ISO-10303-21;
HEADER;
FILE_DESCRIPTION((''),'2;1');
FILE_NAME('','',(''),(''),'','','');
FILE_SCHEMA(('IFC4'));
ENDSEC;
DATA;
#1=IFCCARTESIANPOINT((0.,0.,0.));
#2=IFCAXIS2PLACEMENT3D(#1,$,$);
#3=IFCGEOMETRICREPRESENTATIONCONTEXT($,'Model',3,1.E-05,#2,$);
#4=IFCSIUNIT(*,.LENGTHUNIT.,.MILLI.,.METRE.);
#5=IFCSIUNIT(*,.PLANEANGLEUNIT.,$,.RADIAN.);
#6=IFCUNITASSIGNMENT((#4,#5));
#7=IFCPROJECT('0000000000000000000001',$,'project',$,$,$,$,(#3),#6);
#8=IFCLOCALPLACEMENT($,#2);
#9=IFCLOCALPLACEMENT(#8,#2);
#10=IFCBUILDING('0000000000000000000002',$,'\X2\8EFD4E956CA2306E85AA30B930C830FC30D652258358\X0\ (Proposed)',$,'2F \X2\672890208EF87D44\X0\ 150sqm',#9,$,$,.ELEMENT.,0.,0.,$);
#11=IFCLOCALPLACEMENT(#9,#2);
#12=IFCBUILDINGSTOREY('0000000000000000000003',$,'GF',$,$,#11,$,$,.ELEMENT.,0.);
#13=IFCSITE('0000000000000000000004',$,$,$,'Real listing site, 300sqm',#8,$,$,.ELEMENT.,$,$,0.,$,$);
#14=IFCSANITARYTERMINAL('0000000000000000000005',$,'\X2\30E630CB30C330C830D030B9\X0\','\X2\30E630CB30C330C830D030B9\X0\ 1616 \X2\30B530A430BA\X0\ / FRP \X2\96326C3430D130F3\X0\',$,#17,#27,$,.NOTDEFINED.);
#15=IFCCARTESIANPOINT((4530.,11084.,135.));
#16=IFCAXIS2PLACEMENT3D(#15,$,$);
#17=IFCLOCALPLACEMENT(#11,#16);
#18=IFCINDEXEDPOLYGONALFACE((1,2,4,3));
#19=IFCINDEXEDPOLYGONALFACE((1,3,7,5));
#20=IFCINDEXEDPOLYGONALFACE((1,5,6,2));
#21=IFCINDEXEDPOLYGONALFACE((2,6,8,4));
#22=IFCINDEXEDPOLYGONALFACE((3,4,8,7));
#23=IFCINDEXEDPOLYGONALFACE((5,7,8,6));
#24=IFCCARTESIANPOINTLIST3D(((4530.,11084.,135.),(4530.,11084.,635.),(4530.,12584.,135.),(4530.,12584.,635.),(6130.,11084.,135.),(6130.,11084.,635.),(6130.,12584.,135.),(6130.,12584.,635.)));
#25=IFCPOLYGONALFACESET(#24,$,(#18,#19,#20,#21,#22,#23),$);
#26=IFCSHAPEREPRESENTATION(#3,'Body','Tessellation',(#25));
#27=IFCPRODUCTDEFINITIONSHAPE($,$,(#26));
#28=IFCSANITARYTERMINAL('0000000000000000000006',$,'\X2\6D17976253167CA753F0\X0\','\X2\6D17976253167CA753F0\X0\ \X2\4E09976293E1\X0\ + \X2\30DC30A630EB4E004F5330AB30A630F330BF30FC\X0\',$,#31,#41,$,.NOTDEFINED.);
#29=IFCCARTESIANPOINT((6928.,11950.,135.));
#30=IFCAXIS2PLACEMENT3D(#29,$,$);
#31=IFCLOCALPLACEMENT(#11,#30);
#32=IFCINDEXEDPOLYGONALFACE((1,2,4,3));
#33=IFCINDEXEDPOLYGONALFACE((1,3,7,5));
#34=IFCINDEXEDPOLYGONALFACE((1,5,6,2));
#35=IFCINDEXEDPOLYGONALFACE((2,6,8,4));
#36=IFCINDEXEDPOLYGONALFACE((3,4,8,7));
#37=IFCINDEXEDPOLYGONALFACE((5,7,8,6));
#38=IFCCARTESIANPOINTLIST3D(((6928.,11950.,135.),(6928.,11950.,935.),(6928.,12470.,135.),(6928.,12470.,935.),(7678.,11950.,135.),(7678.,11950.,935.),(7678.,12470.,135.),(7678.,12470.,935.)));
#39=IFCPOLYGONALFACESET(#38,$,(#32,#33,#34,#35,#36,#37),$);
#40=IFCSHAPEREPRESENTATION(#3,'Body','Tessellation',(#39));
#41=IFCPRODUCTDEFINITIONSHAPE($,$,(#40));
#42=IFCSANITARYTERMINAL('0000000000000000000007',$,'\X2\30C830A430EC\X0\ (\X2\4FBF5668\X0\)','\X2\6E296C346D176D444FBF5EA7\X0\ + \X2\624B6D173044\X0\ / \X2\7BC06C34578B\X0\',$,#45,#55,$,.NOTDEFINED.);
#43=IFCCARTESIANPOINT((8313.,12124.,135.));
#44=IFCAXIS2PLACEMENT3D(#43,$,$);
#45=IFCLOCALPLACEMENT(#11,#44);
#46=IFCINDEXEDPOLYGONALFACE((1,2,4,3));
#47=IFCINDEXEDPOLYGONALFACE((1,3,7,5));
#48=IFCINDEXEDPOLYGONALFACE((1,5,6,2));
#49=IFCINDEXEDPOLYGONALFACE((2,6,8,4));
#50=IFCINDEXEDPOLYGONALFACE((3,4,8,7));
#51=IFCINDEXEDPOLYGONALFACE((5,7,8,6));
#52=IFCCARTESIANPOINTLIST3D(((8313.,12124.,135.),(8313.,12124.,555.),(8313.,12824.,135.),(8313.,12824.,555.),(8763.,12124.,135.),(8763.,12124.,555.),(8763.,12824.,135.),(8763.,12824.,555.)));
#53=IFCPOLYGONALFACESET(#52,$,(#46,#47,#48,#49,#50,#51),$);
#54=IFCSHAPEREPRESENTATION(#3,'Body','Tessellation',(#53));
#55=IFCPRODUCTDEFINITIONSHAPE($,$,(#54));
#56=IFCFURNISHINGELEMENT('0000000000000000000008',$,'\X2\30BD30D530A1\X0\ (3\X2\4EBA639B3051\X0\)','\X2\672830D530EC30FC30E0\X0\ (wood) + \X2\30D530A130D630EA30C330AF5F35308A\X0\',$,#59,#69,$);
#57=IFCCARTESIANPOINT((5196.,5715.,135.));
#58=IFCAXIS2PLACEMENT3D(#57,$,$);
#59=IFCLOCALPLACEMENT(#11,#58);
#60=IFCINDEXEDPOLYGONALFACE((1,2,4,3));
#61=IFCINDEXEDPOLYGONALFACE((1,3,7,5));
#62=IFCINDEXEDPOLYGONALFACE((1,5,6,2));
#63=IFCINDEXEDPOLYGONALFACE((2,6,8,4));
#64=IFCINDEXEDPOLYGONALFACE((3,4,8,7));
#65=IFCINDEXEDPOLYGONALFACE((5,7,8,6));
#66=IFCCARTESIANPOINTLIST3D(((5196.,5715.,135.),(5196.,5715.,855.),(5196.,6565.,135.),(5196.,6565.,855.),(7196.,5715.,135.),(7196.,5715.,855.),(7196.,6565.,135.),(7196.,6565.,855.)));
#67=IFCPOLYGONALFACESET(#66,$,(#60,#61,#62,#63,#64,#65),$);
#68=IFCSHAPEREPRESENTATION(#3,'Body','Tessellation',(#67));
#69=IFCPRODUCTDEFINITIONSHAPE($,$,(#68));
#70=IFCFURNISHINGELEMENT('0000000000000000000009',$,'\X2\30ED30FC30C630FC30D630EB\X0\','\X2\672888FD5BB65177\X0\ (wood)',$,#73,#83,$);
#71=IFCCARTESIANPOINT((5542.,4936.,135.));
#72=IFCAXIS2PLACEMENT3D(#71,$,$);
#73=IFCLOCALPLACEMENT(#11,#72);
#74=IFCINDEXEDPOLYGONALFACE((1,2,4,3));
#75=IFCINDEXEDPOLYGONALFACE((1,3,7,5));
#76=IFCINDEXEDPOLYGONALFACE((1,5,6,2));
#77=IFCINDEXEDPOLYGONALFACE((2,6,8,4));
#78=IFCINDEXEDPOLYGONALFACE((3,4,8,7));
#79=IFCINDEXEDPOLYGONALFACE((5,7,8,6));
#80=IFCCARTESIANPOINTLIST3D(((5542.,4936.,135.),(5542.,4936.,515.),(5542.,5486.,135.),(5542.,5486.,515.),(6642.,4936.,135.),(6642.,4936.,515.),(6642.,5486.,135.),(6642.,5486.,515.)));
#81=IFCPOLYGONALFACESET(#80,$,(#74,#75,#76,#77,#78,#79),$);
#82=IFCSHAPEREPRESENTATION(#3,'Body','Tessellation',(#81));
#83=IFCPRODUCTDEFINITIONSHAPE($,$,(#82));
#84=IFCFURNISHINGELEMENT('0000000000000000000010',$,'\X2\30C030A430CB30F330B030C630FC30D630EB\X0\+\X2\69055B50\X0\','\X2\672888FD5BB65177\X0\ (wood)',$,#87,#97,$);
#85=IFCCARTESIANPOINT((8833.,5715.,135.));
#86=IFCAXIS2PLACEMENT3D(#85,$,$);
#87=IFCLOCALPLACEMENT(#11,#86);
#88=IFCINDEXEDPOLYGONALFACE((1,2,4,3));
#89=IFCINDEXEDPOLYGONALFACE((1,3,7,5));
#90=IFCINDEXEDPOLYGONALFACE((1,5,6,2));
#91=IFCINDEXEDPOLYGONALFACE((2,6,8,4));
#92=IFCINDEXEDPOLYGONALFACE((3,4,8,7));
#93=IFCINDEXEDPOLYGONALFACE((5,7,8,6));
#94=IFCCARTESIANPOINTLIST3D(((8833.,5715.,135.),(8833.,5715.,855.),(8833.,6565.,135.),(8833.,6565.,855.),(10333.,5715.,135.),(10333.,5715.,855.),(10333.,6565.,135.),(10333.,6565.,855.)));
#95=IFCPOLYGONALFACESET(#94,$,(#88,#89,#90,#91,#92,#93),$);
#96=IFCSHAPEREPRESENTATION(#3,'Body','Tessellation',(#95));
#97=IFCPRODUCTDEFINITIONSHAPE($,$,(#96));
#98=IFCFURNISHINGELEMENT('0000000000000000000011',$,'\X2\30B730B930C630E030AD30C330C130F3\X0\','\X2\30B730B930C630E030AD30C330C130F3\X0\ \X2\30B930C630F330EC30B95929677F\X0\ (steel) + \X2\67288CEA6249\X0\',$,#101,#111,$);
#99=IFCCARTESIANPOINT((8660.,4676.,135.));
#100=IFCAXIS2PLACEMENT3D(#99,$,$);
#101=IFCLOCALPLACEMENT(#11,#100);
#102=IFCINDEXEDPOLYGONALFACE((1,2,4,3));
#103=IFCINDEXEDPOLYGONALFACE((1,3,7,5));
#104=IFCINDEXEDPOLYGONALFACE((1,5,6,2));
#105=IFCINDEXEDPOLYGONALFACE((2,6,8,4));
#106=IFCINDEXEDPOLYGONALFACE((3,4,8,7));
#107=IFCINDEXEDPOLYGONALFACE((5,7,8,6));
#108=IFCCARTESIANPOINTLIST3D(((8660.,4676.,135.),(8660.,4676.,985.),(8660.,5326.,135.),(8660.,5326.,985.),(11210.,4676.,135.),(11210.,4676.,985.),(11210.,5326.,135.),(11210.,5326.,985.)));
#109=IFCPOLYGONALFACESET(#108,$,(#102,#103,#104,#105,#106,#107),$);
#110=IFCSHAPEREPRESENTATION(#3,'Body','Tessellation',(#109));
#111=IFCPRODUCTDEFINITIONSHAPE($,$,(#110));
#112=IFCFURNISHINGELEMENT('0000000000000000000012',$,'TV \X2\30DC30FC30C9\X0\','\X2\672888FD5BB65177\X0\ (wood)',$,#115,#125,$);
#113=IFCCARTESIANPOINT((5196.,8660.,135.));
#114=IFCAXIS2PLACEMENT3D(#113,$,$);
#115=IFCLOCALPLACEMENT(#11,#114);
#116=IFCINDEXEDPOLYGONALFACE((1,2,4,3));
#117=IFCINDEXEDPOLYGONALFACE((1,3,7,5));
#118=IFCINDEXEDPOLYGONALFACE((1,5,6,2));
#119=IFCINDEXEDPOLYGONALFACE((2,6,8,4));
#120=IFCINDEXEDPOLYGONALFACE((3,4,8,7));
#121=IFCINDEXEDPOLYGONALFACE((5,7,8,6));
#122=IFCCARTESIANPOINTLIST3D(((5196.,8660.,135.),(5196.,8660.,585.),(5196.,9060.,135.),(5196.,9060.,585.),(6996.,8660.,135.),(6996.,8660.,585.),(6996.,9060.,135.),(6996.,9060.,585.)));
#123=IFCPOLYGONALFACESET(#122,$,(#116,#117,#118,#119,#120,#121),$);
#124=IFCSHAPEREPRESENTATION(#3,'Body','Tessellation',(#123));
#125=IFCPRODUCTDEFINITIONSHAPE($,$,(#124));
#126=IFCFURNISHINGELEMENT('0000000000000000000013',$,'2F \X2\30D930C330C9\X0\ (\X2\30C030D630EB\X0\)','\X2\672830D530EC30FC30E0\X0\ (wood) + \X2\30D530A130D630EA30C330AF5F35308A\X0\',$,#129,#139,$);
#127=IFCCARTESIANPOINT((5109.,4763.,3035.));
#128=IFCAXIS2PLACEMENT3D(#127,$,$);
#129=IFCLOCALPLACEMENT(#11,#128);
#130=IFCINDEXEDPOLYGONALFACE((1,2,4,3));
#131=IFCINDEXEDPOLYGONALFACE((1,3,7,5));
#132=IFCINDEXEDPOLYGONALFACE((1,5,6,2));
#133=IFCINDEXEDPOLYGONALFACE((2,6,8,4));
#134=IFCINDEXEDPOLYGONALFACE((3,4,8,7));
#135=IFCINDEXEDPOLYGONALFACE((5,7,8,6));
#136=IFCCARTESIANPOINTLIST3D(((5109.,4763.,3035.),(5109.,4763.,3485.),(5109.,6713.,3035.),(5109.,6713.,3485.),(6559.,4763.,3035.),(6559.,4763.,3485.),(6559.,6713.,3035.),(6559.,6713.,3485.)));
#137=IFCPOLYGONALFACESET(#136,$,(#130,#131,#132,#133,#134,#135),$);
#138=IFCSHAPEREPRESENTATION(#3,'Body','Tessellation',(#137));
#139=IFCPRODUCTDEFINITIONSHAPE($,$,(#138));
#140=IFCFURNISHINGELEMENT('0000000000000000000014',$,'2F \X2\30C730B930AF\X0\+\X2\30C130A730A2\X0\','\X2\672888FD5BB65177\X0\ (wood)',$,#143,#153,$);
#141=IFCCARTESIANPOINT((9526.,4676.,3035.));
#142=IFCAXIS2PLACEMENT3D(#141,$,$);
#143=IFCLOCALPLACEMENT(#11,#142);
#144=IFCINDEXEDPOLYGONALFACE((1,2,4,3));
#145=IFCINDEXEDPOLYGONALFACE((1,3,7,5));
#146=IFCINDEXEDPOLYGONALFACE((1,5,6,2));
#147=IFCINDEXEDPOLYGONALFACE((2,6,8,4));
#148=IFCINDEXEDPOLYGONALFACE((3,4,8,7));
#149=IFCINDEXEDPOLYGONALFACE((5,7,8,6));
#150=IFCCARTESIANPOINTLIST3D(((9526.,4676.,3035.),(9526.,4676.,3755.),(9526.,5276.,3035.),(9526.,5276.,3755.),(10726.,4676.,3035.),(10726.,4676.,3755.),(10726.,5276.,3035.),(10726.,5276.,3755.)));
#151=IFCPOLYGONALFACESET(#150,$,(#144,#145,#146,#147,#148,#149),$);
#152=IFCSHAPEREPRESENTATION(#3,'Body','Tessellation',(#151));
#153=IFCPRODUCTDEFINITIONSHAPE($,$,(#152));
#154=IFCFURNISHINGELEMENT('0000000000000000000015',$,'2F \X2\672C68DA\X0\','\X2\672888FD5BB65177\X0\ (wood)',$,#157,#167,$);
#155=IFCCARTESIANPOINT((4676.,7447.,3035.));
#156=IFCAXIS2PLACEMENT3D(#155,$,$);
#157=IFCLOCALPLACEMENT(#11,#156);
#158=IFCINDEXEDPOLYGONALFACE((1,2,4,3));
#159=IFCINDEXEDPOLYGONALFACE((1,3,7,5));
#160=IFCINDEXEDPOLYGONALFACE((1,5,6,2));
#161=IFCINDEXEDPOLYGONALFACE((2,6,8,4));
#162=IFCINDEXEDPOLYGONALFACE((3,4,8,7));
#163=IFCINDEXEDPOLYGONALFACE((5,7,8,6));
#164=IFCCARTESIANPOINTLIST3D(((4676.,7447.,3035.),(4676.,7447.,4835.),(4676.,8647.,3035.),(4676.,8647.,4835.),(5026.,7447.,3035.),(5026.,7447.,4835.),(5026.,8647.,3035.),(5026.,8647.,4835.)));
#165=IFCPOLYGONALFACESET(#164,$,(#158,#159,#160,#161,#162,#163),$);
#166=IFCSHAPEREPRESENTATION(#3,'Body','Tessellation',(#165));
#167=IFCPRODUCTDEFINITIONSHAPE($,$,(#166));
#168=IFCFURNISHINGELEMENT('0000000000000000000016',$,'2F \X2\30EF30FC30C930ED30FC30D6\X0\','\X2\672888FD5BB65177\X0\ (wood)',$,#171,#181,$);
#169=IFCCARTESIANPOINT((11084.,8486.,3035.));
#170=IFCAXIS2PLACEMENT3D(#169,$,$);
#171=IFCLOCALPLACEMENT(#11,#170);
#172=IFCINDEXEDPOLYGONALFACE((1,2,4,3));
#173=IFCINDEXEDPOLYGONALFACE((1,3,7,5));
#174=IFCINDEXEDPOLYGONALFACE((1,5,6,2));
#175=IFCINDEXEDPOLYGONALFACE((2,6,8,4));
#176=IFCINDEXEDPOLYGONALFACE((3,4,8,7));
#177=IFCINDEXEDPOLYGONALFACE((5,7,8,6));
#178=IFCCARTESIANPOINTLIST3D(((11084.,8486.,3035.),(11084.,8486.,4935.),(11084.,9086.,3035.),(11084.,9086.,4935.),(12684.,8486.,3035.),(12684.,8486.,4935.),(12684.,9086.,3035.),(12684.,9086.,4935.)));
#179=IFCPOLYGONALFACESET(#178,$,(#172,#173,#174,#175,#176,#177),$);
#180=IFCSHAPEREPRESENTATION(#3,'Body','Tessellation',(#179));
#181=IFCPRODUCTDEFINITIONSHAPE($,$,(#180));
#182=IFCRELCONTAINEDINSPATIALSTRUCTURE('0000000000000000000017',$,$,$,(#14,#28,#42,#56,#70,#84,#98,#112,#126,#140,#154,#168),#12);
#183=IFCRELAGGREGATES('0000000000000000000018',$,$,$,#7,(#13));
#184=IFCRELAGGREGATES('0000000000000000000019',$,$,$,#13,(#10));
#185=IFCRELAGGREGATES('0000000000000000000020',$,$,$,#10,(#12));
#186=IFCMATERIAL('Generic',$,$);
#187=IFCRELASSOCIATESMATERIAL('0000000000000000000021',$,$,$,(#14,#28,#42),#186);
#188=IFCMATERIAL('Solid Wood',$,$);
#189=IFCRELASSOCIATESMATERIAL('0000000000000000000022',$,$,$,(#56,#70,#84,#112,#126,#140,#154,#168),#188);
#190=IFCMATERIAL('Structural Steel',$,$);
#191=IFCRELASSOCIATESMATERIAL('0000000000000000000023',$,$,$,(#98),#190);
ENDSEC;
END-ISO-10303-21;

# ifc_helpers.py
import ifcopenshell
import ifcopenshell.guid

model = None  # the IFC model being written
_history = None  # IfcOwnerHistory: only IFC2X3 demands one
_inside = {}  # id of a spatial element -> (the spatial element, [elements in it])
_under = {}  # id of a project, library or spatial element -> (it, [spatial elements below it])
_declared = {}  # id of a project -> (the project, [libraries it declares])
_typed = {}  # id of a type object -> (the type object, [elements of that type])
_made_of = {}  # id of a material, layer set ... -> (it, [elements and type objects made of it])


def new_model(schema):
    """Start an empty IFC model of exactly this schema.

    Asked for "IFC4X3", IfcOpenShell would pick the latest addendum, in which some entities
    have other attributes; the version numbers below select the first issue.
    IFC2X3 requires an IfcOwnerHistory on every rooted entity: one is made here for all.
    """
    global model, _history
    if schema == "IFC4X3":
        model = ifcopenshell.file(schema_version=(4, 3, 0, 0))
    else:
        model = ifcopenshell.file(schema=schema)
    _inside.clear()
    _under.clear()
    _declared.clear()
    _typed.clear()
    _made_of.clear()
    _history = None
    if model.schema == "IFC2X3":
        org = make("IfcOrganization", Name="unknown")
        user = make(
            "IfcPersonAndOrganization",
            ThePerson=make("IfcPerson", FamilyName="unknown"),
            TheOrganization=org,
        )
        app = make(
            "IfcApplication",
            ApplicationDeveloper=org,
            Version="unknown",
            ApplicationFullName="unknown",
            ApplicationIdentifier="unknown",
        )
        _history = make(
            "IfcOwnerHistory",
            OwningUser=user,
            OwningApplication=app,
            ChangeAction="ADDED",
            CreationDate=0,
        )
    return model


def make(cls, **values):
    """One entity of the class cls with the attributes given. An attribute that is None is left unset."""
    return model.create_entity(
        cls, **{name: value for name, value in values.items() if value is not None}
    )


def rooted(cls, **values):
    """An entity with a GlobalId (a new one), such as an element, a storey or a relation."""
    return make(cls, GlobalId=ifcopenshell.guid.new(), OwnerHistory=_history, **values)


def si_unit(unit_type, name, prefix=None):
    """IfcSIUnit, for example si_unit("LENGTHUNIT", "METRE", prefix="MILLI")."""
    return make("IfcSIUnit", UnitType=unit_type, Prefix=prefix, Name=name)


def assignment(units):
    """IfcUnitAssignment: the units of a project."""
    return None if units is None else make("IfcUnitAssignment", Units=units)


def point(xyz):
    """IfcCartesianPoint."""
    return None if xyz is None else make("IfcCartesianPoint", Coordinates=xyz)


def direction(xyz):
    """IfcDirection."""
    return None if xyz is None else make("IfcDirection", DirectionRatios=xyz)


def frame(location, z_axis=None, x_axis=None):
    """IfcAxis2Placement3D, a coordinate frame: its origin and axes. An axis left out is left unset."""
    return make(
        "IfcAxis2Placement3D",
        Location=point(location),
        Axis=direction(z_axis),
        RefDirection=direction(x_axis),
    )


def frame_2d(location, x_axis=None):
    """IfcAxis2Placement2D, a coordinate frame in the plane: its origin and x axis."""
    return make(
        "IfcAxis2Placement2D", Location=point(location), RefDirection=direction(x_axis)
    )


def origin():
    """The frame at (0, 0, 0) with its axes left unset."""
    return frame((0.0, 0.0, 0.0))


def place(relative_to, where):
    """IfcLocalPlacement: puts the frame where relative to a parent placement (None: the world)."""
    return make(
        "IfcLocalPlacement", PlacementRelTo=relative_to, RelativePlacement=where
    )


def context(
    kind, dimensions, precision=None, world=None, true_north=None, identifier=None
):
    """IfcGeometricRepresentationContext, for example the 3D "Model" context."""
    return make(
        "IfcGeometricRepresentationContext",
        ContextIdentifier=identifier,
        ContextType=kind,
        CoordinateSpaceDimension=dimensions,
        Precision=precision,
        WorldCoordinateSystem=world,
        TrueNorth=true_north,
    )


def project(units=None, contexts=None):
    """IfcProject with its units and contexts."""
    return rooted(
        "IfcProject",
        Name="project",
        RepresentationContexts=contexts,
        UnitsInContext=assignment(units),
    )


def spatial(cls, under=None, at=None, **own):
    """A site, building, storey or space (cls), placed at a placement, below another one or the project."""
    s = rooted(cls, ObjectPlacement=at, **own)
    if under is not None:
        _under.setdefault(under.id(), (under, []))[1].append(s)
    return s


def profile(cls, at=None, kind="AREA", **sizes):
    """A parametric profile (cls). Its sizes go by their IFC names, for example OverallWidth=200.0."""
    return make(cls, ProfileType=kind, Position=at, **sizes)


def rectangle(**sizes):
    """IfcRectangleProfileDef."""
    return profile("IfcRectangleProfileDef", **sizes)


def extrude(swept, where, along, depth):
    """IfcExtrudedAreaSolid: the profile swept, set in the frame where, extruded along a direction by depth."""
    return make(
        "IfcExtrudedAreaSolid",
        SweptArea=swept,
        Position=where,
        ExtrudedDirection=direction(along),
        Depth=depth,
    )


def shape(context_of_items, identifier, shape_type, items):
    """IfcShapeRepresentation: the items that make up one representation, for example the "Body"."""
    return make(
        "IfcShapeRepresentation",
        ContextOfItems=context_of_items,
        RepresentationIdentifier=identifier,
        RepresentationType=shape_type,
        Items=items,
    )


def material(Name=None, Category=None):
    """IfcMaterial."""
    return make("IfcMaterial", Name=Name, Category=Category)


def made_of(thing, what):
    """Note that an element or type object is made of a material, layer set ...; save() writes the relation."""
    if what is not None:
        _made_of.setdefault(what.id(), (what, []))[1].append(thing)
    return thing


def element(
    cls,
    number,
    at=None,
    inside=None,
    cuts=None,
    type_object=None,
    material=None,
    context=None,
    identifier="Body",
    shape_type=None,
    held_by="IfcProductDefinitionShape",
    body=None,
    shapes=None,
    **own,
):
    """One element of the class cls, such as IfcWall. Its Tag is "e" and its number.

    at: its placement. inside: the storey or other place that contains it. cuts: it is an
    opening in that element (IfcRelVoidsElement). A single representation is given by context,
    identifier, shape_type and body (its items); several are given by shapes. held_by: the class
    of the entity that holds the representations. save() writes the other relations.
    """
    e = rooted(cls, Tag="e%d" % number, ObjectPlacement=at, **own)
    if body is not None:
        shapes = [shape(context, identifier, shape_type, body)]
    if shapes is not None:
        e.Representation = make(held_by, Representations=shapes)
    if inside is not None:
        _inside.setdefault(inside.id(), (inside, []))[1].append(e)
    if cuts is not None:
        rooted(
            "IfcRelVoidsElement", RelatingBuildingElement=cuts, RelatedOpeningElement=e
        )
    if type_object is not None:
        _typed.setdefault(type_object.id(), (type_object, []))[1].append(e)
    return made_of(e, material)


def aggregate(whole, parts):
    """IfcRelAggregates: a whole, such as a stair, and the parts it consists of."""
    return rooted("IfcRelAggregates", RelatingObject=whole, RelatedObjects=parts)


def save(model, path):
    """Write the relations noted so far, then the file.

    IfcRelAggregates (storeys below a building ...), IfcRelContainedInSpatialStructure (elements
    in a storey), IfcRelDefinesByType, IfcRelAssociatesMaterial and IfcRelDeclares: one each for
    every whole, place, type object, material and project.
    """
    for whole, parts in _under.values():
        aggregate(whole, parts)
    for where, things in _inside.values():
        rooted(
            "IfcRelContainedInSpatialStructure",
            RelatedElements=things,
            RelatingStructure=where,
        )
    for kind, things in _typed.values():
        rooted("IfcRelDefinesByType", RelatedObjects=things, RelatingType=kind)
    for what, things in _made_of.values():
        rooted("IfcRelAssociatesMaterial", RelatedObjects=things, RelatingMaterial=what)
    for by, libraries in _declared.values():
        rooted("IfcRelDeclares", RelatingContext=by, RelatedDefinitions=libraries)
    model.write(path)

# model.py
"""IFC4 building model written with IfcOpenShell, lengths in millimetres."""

from ifc_helpers import new_model, si_unit, frame, frame_2d, origin, place, context, project, spatial, rectangle, extrude, material, element, save


model = new_model("IFC4")

# Units and contexts
model_context = context("Model", 3, precision=1e-05, world=origin())
ifc_project = project(units=[si_unit("LENGTHUNIT", "METRE", prefix="MILLI"), si_unit("PLANEANGLEUNIT", "RADIAN")], contexts=[model_context])

# Site, building, storey
site_placement = place(None, origin())
site = spatial("IfcSite", under=ifc_project, at=site_placement, ObjectType="Real listing site, 300sqm", CompositionType="ELEMENT", RefElevation=0.0)
building_placement = place(site_placement, origin())
building = spatial("IfcBuilding", under=site, at=building_placement, Name="軽井沢の薪ストーブ別荘 (Proposed)", ObjectType="2F 木造軸組 150sqm", CompositionType="ELEMENT", ElevationOfRefHeight=0.0, ElevationOfTerrain=0.0)
storey_placement = place(building_placement, origin())
storey = spatial("IfcBuildingStorey", under=building, at=storey_placement, Name="GF", CompositionType="ELEMENT", Elevation=0.0)

# Shared definitions
ifc_material_1 = material(Name="Solid Wood")

# Sanitary terminals
ifc_material_2 = material(Name="Generic")
sanitary_terminal_1_placement = place(storey_placement, frame((4530.0, 11084.0, 135.0)))
element("IfcSanitaryTerminal", 1, at=sanitary_terminal_1_placement, inside=storey, material=ifc_material_2, Name="ユニットバス", Description="ユニットバス 1616 サイズ / FRP 防水パン", PredefinedType="NOTDEFINED", context=model_context, shape_type="SweptSolid", body=[
    extrude(rectangle(XDim=1600.0, YDim=1500.0, at=frame_2d((800.0, 750.0))), frame((4530.0, 11084.0, 135.0)), (0.0, 0.0, 1.0), 500.0),
])
sanitary_terminal_2_placement = place(storey_placement, frame((6928.0, 11950.0, 135.0)))
element("IfcSanitaryTerminal", 2, at=sanitary_terminal_2_placement, inside=storey, material=ifc_material_2, Name="洗面化粧台", Description="洗面化粧台 三面鏡 + ボウル一体カウンター", PredefinedType="NOTDEFINED", context=model_context, shape_type="SweptSolid", body=[
    extrude(rectangle(XDim=750.0, YDim=520.0, at=frame_2d((375.0, 260.0))), frame((6928.0, 11950.0, 135.0)), (0.0, 0.0, 1.0), 800.0),
])
sanitary_terminal_3_placement = place(storey_placement, frame((8313.0, 12124.0, 135.0)))
element("IfcSanitaryTerminal", 3, at=sanitary_terminal_3_placement, inside=storey, material=ifc_material_2, Name="トイレ (便器)", Description="温水洗浄便座 + 手洗い / 節水型", PredefinedType="NOTDEFINED", context=model_context, shape_type="SweptSolid", body=[
    extrude(rectangle(XDim=450.0, YDim=700.0, at=frame_2d((225.0, 350.0))), frame((8313.0, 12124.0, 135.0)), (0.0, 0.0, 1.0), 420.0),
])

# Furnishing elements
furnishing_1_placement = place(storey_placement, frame((5196.0, 5715.0, 135.0)))
element("IfcFurnishingElement", 4, at=furnishing_1_placement, inside=storey, material=ifc_material_1, Name="ソファ (3人掛け)", Description="木フレーム (wood) + ファブリック張り", context=model_context, shape_type="SweptSolid", body=[
    extrude(rectangle(XDim=2000.0, YDim=850.0, at=frame_2d((1000.0, 425.0))), frame((5196.0, 5715.0, 135.0)), (0.0, 0.0, 1.0), 720.0),
])
furnishing_2_placement = place(storey_placement, frame((5542.0, 4936.0, 135.0)))
element("IfcFurnishingElement", 5, at=furnishing_2_placement, inside=storey, material=ifc_material_1, Name="ローテーブル", Description="木製家具 (wood)", context=model_context, shape_type="SweptSolid", body=[
    extrude(rectangle(XDim=1100.0, YDim=550.0, at=frame_2d((550.0, 275.0))), frame((5542.0, 4936.0, 135.0)), (0.0, 0.0, 1.0), 380.0),
])
furnishing_3_placement = place(storey_placement, frame((8833.0, 5715.0, 135.0)))
element("IfcFurnishingElement", 6, at=furnishing_3_placement, inside=storey, material=ifc_material_1, Name="ダイニングテーブル+椅子", Description="木製家具 (wood)", context=model_context, shape_type="SweptSolid", body=[
    extrude(rectangle(XDim=1500.0, YDim=850.0, at=frame_2d((750.0, 425.0))), frame((8833.0, 5715.0, 135.0)), (0.0, 0.0, 1.0), 720.0),
])
ifc_material_3 = material(Name="Structural Steel")
furnishing_4_placement = place(storey_placement, frame((8660.0, 4676.0, 135.0)))
element("IfcFurnishingElement", 7, at=furnishing_4_placement, inside=storey, material=ifc_material_3, Name="システムキッチン", Description="システムキッチン ステンレス天板 (steel) + 木質扉", context=model_context, shape_type="SweptSolid", body=[
    extrude(rectangle(XDim=2550.0, YDim=650.0, at=frame_2d((1275.0, 325.0))), frame((8660.0, 4676.0, 135.0)), (0.0, 0.0, 1.0), 850.0),
])
furnishing_5_placement = place(storey_placement, frame((5196.0, 8660.0, 135.0)))
element("IfcFurnishingElement", 8, at=furnishing_5_placement, inside=storey, material=ifc_material_1, Name="TV ボード", Description="木製家具 (wood)", context=model_context, shape_type="SweptSolid", body=[
    extrude(rectangle(XDim=1800.0, YDim=400.0, at=frame_2d((900.0, 200.0))), frame((5196.0, 8660.0, 135.0)), (0.0, 0.0, 1.0), 450.0),
])
furnishing_6_placement = place(storey_placement, frame((5109.0, 4763.0, 3035.0)))
element("IfcFurnishingElement", 9, at=furnishing_6_placement, inside=storey, material=ifc_material_1, Name="2F ベッド (ダブル)", Description="木フレーム (wood) + ファブリック張り", context=model_context, shape_type="SweptSolid", body=[
    extrude(rectangle(XDim=1450.0, YDim=1950.0, at=frame_2d((725.0, 975.0))), frame((5109.0, 4763.0, 3035.0)), (0.0, 0.0, 1.0), 450.0),
])
furnishing_7_placement = place(storey_placement, frame((9526.0, 4676.0, 3035.0)))
element("IfcFurnishingElement", 10, at=furnishing_7_placement, inside=storey, material=ifc_material_1, Name="2F デスク+チェア", Description="木製家具 (wood)", context=model_context, shape_type="SweptSolid", body=[
    extrude(rectangle(XDim=1200.0, YDim=600.0, at=frame_2d((600.0, 300.0))), frame((9526.0, 4676.0, 3035.0)), (0.0, 0.0, 1.0), 720.0),
])
furnishing_8_placement = place(storey_placement, frame((4676.0, 7447.0, 3035.0)))
element("IfcFurnishingElement", 11, at=furnishing_8_placement, inside=storey, material=ifc_material_1, Name="2F 本棚", Description="木製家具 (wood)", context=model_context, shape_type="SweptSolid", body=[
    extrude(rectangle(XDim=350.0, YDim=1200.0, at=frame_2d((175.0, 600.0))), frame((4676.0, 7447.0, 3035.0)), (0.0, 0.0, 1.0), 1800.0),
])
furnishing_9_placement = place(storey_placement, frame((11084.0, 8486.0, 3035.0)))
element("IfcFurnishingElement", 12, at=furnishing_9_placement, inside=storey, material=ifc_material_1, Name="2F ワードローブ", Description="木製家具 (wood)", context=model_context, shape_type="SweptSolid", body=[
    extrude(rectangle(XDim=1600.0, YDim=600.0, at=frame_2d((800.0, 300.0))), frame((11084.0, 8486.0, 3035.0)), (0.0, 0.0, 1.0), 1900.0),
])

save(model, "model.ifc")
